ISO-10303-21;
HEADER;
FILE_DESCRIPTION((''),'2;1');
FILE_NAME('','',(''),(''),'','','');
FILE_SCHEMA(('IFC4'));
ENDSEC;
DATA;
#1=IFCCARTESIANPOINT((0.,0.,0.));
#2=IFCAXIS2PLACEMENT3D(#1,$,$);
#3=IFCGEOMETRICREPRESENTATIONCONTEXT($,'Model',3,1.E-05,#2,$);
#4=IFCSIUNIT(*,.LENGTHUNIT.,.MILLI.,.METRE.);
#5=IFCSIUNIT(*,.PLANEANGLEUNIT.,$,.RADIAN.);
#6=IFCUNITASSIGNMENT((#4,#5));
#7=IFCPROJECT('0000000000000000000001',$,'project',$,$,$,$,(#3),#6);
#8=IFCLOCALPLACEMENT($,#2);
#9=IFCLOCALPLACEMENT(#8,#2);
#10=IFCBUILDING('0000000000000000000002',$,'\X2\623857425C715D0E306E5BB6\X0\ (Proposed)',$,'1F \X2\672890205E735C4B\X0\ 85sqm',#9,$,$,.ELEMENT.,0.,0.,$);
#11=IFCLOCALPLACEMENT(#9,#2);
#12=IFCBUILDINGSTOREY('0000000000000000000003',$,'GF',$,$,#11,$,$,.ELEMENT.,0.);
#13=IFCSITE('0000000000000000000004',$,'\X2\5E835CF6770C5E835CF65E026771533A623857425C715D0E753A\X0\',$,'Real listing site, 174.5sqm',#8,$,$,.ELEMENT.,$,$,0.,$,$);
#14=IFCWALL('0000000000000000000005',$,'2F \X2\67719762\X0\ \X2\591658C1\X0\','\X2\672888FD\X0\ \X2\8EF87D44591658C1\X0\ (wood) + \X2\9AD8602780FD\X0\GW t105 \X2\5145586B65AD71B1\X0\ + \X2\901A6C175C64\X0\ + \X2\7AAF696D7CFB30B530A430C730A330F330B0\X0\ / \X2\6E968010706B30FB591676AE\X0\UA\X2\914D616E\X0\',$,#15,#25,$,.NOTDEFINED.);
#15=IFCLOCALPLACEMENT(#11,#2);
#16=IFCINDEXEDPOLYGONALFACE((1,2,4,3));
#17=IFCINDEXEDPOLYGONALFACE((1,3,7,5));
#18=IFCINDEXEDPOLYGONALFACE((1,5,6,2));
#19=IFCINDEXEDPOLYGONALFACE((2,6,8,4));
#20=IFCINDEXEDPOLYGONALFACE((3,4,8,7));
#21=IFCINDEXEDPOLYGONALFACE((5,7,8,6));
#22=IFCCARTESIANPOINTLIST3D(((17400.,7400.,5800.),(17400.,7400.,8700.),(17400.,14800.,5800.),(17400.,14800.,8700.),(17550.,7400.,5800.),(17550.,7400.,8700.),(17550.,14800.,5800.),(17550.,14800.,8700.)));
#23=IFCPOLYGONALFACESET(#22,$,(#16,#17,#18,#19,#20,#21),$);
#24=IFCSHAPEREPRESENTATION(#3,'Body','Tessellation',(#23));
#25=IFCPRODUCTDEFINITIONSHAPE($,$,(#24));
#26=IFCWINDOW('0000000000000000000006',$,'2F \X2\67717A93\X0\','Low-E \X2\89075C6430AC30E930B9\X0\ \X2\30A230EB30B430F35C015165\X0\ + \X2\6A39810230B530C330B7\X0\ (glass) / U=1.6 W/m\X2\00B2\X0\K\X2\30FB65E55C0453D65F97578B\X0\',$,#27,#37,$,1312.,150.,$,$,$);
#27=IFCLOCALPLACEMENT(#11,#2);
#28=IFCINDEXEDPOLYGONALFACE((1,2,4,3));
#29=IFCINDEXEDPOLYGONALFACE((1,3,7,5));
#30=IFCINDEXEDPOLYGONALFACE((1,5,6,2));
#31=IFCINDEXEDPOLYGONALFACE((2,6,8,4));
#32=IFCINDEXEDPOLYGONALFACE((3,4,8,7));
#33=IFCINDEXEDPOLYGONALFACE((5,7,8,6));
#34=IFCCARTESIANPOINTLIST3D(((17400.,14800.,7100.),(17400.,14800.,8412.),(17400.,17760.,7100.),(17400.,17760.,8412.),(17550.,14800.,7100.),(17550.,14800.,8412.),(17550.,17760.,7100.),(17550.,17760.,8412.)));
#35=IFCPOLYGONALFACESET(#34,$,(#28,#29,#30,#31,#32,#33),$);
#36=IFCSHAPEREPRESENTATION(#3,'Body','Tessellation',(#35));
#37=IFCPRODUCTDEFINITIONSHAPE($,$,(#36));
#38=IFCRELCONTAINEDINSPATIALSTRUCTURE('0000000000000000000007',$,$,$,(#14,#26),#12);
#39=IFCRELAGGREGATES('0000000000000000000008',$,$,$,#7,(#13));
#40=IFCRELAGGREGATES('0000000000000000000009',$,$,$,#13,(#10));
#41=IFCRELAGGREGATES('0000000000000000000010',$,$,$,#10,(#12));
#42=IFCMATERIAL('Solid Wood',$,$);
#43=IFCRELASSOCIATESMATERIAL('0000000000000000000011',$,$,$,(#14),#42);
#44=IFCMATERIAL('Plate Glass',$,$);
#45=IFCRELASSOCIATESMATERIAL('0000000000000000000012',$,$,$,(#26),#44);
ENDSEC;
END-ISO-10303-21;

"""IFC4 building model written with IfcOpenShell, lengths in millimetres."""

from ifc_helpers import new_model, si_unit, frame, frame_2d, origin, place, context, project, spatial, rectangle, extrude, material, element, fill, save


model = new_model("IFC4")

# Units and contexts
model_context = context("Model", 3, precision=1e-05, world=origin())
ifc_project = project(units=[si_unit("LENGTHUNIT", "METRE", prefix="MILLI"), si_unit("PLANEANGLEUNIT", "RADIAN")], contexts=[model_context])

# Site, building, storey
site_placement = place(None, origin())
site = spatial("IfcSite", under=ifc_project, at=site_placement, Name="広島県広島市東区戸坂山崎町", ObjectType="Real listing site, 174.5sqm", CompositionType="ELEMENT", RefElevation=0.0)
building_placement = place(site_placement, origin())
building = spatial("IfcBuilding", under=site, at=building_placement, Name="戸坂山崎の家 (Proposed)", ObjectType="1F 木造平屋 85sqm", CompositionType="ELEMENT", ElevationOfRefHeight=0.0, ElevationOfTerrain=0.0)
storey_placement = place(building_placement, origin())
storey = spatial("IfcBuildingStorey", under=building, at=storey_placement, Name="GF", CompositionType="ELEMENT", Elevation=0.0)

# Shared definitions
ifc_material_1 = material(Name="Solid Wood")

# Shared definitions
ifc_material_2 = material(Name="Plate Glass")

# Wall, opening, window
wall_1_placement = place(storey_placement, frame((8700.0, 3700.0, 2900.0)))
wall_1 = element("IfcWall", 1, at=wall_1_placement, inside=storey, material=ifc_material_1, Name="2F 東面 外壁", Description="木製 軸組外壁 (wood) + 高性能GW t105 充填断熱 + 通気層 + 窯業系サイディング / 準耐火・外皮UA配慮", PredefinedType="NOTDEFINED", context=model_context, shape_type="SweptSolid", body=[
    extrude(rectangle(XDim=150.0, YDim=7400.0, at=frame_2d((75.0, 3700.0))), frame((8700.0, 3700.0, 2900.0)), (0.0, 0.0, 1.0), 2900.0),
])
opening_1_placement = place(storey_placement, frame((8700.0, 7400.0, 3550.0)))
opening_1 = element("IfcOpeningElement", 2, at=opening_1_placement, cuts=wall_1, PredefinedType="NOTDEFINED", context=model_context, shape_type="SweptSolid", body=[
    extrude(rectangle(XDim=150.0, YDim=2960.0, at=frame_2d((75.0, 1480.0))), frame((8700.0, 7400.0, 3550.0)), (0.0, 0.0, 1.0), 1312.0),
])
window_1_placement = place(storey_placement, frame((8700.0, 7400.0, 3550.0)))
window_1 = element("IfcWindow", 3, at=window_1_placement, inside=storey, material=ifc_material_2, Name="2F 東窓", Description="Low-E 複層ガラス アルゴン封入 + 樹脂サッシ (glass) / U=1.6 W/m²K・日射取得型", OverallHeight=1312.0, OverallWidth=150.0, context=model_context, shape_type="SweptSolid", body=[
    extrude(rectangle(XDim=150.0, YDim=2960.0, at=frame_2d((75.0, 1480.0))), frame((8700.0, 7400.0, 3550.0)), (0.0, 0.0, 1.0), 1312.0),
])
fill(opening_1, window_1)

save(model, "model.ifc")
